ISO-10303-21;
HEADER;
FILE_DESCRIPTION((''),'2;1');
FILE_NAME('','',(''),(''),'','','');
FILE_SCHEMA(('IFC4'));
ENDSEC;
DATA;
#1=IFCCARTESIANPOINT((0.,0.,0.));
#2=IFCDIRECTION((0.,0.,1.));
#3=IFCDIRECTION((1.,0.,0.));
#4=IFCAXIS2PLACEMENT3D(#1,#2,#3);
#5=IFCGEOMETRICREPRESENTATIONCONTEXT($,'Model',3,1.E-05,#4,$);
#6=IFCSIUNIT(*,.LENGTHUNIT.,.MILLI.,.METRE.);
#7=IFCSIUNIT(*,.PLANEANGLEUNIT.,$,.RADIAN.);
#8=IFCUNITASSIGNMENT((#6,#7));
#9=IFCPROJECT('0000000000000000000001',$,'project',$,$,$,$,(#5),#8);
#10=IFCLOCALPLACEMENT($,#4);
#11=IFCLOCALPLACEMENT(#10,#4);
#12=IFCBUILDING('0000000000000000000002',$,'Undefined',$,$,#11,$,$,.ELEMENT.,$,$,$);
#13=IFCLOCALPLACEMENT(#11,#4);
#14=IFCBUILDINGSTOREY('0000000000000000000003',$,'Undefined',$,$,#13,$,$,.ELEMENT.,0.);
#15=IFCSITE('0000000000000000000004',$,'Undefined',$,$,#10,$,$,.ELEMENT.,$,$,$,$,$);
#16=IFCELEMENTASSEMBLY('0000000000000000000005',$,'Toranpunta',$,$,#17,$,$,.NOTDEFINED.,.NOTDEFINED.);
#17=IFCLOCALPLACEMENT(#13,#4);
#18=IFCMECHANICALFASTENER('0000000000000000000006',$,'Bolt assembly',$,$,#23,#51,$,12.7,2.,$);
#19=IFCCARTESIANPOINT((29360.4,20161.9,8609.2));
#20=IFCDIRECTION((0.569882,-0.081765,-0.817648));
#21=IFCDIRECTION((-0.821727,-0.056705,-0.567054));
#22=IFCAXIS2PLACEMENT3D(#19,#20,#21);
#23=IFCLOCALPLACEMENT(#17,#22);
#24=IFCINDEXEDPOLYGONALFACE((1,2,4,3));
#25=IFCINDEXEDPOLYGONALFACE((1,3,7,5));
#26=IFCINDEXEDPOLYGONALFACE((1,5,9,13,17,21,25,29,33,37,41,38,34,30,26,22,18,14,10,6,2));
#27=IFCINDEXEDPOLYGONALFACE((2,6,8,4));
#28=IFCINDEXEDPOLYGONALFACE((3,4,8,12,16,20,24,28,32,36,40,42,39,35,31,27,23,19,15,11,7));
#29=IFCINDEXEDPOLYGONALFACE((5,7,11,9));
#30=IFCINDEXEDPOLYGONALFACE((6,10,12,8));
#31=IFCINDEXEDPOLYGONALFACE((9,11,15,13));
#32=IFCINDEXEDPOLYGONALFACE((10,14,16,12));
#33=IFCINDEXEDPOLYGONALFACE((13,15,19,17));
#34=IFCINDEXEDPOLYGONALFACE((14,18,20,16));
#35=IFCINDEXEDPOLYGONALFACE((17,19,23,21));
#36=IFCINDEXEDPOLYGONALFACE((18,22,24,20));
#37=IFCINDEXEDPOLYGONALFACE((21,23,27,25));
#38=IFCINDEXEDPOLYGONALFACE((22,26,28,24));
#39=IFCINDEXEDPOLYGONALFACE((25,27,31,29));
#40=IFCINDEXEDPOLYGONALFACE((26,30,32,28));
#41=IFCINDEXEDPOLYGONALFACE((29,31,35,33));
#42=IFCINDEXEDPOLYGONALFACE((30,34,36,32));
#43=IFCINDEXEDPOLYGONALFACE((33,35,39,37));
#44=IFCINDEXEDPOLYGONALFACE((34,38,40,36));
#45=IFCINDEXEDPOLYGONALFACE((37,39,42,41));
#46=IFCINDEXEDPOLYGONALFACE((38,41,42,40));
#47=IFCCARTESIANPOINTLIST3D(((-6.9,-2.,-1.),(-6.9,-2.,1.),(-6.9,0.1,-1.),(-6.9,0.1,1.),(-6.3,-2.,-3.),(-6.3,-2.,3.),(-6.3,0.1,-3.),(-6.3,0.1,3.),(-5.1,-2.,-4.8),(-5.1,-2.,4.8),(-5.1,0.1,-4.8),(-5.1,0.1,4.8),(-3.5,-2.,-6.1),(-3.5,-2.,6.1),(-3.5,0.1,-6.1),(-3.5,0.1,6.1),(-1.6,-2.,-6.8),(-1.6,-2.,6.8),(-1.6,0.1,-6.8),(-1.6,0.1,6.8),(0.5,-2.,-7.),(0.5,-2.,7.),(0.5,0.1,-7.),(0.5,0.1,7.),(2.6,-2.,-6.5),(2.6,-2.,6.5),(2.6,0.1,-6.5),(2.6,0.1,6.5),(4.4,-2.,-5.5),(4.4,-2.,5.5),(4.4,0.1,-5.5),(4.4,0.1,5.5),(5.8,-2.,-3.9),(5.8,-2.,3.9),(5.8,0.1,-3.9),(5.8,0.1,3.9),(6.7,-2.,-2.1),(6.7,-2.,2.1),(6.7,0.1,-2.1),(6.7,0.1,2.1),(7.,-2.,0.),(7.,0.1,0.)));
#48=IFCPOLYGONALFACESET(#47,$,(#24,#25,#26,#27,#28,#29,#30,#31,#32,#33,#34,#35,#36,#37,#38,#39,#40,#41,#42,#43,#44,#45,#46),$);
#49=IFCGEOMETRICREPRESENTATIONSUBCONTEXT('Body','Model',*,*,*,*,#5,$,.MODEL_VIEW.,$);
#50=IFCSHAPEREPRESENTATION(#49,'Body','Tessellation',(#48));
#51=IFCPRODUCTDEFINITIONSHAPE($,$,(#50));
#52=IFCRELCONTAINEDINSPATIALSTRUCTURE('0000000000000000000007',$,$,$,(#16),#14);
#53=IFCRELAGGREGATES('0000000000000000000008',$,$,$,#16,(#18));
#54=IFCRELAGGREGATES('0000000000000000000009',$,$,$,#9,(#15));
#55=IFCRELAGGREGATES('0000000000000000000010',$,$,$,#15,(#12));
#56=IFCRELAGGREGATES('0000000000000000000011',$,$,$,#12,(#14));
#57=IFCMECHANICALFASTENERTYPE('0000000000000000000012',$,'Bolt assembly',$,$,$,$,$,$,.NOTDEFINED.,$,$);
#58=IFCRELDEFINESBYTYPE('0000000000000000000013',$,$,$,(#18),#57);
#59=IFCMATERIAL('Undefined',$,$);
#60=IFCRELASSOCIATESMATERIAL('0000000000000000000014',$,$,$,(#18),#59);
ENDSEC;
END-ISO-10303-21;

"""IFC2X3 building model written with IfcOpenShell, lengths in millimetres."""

from ifc_helpers import new_model, si_unit, frame, origin_with_axes, origin_2d_with_axis, place, context, subcontext, project, spatial, circle, extrude, source, transform, mapped, material, type_object, element, aggregate, save


model = new_model("IFC2X3")

# Units and contexts
model_context = context("Model", 3, precision=1e-05, world=origin_with_axes())
body_context = subcontext(model_context, "Body", "Model", "MODEL_VIEW")
ifc_project = project(units=[si_unit("LENGTHUNIT", "METRE", prefix="MILLI"), si_unit("PLANEANGLEUNIT", "RADIAN")], contexts=[model_context])

# Site, building, storey
site_placement = place(None, origin_with_axes())
site = spatial("IfcSite", under=ifc_project, at=site_placement, Name="Undefined", CompositionType="ELEMENT")
building_placement = place(site_placement, origin_with_axes())
building = spatial("IfcBuilding", under=site, at=building_placement, Name="Undefined", CompositionType="ELEMENT")
storey_placement = place(building_placement, origin_with_axes())
storey = spatial("IfcBuildingStorey", under=building, at=storey_placement, Name="Undefined", CompositionType="ELEMENT", Elevation=0.0)

# Shared definitions
ifc_material_1 = material(Name="Undefined")
mechanical_fastener_type = type_object("IfcMechanicalFastenerType", Name="Bolt assembly")

# Element assembly, mechanical fastener
assembly_1_placement = place(storey_placement, origin_with_axes())
assembly_1 = element("IfcElementAssembly", 1, at=assembly_1_placement, inside=storey, Name="Toranpunta", AssemblyPlace="NOTDEFINED", PredefinedType="NOTDEFINED")
shared_shape_1 = source(origin_with_axes(), body_context, "Body", "SweptSolid", [
    extrude(circle(Radius=7.0, at=origin_2d_with_axis()), frame((0.0, -2.0, 0.0), z_axis=(0.0, 1.0, 0.0), x_axis=(1.0, 0.0, 0.0)), (0.0, 0.0, 1.0), 2.1),
])
mechanical_fastener_1_placement = place(assembly_1_placement, frame((29360.4, 20161.9, 8609.2), z_axis=(0.569882, -0.081765, -0.817648), x_axis=(-0.821727, -0.056705, -0.567054)))
mechanical_fastener_1 = element("IfcMechanicalFastener", 2, at=mechanical_fastener_1_placement, type_object=mechanical_fastener_type, material=ifc_material_1, Name="Bolt assembly", NominalDiameter=12.7, NominalLength=2.0, context=body_context, shape_type="MappedRepresentation", body=[
    mapped(shared_shape_1, transform((0.0, 0.0, 0.0))),
])
aggregate(assembly_1, [mechanical_fastener_1])

save(model, "model.ifc")
